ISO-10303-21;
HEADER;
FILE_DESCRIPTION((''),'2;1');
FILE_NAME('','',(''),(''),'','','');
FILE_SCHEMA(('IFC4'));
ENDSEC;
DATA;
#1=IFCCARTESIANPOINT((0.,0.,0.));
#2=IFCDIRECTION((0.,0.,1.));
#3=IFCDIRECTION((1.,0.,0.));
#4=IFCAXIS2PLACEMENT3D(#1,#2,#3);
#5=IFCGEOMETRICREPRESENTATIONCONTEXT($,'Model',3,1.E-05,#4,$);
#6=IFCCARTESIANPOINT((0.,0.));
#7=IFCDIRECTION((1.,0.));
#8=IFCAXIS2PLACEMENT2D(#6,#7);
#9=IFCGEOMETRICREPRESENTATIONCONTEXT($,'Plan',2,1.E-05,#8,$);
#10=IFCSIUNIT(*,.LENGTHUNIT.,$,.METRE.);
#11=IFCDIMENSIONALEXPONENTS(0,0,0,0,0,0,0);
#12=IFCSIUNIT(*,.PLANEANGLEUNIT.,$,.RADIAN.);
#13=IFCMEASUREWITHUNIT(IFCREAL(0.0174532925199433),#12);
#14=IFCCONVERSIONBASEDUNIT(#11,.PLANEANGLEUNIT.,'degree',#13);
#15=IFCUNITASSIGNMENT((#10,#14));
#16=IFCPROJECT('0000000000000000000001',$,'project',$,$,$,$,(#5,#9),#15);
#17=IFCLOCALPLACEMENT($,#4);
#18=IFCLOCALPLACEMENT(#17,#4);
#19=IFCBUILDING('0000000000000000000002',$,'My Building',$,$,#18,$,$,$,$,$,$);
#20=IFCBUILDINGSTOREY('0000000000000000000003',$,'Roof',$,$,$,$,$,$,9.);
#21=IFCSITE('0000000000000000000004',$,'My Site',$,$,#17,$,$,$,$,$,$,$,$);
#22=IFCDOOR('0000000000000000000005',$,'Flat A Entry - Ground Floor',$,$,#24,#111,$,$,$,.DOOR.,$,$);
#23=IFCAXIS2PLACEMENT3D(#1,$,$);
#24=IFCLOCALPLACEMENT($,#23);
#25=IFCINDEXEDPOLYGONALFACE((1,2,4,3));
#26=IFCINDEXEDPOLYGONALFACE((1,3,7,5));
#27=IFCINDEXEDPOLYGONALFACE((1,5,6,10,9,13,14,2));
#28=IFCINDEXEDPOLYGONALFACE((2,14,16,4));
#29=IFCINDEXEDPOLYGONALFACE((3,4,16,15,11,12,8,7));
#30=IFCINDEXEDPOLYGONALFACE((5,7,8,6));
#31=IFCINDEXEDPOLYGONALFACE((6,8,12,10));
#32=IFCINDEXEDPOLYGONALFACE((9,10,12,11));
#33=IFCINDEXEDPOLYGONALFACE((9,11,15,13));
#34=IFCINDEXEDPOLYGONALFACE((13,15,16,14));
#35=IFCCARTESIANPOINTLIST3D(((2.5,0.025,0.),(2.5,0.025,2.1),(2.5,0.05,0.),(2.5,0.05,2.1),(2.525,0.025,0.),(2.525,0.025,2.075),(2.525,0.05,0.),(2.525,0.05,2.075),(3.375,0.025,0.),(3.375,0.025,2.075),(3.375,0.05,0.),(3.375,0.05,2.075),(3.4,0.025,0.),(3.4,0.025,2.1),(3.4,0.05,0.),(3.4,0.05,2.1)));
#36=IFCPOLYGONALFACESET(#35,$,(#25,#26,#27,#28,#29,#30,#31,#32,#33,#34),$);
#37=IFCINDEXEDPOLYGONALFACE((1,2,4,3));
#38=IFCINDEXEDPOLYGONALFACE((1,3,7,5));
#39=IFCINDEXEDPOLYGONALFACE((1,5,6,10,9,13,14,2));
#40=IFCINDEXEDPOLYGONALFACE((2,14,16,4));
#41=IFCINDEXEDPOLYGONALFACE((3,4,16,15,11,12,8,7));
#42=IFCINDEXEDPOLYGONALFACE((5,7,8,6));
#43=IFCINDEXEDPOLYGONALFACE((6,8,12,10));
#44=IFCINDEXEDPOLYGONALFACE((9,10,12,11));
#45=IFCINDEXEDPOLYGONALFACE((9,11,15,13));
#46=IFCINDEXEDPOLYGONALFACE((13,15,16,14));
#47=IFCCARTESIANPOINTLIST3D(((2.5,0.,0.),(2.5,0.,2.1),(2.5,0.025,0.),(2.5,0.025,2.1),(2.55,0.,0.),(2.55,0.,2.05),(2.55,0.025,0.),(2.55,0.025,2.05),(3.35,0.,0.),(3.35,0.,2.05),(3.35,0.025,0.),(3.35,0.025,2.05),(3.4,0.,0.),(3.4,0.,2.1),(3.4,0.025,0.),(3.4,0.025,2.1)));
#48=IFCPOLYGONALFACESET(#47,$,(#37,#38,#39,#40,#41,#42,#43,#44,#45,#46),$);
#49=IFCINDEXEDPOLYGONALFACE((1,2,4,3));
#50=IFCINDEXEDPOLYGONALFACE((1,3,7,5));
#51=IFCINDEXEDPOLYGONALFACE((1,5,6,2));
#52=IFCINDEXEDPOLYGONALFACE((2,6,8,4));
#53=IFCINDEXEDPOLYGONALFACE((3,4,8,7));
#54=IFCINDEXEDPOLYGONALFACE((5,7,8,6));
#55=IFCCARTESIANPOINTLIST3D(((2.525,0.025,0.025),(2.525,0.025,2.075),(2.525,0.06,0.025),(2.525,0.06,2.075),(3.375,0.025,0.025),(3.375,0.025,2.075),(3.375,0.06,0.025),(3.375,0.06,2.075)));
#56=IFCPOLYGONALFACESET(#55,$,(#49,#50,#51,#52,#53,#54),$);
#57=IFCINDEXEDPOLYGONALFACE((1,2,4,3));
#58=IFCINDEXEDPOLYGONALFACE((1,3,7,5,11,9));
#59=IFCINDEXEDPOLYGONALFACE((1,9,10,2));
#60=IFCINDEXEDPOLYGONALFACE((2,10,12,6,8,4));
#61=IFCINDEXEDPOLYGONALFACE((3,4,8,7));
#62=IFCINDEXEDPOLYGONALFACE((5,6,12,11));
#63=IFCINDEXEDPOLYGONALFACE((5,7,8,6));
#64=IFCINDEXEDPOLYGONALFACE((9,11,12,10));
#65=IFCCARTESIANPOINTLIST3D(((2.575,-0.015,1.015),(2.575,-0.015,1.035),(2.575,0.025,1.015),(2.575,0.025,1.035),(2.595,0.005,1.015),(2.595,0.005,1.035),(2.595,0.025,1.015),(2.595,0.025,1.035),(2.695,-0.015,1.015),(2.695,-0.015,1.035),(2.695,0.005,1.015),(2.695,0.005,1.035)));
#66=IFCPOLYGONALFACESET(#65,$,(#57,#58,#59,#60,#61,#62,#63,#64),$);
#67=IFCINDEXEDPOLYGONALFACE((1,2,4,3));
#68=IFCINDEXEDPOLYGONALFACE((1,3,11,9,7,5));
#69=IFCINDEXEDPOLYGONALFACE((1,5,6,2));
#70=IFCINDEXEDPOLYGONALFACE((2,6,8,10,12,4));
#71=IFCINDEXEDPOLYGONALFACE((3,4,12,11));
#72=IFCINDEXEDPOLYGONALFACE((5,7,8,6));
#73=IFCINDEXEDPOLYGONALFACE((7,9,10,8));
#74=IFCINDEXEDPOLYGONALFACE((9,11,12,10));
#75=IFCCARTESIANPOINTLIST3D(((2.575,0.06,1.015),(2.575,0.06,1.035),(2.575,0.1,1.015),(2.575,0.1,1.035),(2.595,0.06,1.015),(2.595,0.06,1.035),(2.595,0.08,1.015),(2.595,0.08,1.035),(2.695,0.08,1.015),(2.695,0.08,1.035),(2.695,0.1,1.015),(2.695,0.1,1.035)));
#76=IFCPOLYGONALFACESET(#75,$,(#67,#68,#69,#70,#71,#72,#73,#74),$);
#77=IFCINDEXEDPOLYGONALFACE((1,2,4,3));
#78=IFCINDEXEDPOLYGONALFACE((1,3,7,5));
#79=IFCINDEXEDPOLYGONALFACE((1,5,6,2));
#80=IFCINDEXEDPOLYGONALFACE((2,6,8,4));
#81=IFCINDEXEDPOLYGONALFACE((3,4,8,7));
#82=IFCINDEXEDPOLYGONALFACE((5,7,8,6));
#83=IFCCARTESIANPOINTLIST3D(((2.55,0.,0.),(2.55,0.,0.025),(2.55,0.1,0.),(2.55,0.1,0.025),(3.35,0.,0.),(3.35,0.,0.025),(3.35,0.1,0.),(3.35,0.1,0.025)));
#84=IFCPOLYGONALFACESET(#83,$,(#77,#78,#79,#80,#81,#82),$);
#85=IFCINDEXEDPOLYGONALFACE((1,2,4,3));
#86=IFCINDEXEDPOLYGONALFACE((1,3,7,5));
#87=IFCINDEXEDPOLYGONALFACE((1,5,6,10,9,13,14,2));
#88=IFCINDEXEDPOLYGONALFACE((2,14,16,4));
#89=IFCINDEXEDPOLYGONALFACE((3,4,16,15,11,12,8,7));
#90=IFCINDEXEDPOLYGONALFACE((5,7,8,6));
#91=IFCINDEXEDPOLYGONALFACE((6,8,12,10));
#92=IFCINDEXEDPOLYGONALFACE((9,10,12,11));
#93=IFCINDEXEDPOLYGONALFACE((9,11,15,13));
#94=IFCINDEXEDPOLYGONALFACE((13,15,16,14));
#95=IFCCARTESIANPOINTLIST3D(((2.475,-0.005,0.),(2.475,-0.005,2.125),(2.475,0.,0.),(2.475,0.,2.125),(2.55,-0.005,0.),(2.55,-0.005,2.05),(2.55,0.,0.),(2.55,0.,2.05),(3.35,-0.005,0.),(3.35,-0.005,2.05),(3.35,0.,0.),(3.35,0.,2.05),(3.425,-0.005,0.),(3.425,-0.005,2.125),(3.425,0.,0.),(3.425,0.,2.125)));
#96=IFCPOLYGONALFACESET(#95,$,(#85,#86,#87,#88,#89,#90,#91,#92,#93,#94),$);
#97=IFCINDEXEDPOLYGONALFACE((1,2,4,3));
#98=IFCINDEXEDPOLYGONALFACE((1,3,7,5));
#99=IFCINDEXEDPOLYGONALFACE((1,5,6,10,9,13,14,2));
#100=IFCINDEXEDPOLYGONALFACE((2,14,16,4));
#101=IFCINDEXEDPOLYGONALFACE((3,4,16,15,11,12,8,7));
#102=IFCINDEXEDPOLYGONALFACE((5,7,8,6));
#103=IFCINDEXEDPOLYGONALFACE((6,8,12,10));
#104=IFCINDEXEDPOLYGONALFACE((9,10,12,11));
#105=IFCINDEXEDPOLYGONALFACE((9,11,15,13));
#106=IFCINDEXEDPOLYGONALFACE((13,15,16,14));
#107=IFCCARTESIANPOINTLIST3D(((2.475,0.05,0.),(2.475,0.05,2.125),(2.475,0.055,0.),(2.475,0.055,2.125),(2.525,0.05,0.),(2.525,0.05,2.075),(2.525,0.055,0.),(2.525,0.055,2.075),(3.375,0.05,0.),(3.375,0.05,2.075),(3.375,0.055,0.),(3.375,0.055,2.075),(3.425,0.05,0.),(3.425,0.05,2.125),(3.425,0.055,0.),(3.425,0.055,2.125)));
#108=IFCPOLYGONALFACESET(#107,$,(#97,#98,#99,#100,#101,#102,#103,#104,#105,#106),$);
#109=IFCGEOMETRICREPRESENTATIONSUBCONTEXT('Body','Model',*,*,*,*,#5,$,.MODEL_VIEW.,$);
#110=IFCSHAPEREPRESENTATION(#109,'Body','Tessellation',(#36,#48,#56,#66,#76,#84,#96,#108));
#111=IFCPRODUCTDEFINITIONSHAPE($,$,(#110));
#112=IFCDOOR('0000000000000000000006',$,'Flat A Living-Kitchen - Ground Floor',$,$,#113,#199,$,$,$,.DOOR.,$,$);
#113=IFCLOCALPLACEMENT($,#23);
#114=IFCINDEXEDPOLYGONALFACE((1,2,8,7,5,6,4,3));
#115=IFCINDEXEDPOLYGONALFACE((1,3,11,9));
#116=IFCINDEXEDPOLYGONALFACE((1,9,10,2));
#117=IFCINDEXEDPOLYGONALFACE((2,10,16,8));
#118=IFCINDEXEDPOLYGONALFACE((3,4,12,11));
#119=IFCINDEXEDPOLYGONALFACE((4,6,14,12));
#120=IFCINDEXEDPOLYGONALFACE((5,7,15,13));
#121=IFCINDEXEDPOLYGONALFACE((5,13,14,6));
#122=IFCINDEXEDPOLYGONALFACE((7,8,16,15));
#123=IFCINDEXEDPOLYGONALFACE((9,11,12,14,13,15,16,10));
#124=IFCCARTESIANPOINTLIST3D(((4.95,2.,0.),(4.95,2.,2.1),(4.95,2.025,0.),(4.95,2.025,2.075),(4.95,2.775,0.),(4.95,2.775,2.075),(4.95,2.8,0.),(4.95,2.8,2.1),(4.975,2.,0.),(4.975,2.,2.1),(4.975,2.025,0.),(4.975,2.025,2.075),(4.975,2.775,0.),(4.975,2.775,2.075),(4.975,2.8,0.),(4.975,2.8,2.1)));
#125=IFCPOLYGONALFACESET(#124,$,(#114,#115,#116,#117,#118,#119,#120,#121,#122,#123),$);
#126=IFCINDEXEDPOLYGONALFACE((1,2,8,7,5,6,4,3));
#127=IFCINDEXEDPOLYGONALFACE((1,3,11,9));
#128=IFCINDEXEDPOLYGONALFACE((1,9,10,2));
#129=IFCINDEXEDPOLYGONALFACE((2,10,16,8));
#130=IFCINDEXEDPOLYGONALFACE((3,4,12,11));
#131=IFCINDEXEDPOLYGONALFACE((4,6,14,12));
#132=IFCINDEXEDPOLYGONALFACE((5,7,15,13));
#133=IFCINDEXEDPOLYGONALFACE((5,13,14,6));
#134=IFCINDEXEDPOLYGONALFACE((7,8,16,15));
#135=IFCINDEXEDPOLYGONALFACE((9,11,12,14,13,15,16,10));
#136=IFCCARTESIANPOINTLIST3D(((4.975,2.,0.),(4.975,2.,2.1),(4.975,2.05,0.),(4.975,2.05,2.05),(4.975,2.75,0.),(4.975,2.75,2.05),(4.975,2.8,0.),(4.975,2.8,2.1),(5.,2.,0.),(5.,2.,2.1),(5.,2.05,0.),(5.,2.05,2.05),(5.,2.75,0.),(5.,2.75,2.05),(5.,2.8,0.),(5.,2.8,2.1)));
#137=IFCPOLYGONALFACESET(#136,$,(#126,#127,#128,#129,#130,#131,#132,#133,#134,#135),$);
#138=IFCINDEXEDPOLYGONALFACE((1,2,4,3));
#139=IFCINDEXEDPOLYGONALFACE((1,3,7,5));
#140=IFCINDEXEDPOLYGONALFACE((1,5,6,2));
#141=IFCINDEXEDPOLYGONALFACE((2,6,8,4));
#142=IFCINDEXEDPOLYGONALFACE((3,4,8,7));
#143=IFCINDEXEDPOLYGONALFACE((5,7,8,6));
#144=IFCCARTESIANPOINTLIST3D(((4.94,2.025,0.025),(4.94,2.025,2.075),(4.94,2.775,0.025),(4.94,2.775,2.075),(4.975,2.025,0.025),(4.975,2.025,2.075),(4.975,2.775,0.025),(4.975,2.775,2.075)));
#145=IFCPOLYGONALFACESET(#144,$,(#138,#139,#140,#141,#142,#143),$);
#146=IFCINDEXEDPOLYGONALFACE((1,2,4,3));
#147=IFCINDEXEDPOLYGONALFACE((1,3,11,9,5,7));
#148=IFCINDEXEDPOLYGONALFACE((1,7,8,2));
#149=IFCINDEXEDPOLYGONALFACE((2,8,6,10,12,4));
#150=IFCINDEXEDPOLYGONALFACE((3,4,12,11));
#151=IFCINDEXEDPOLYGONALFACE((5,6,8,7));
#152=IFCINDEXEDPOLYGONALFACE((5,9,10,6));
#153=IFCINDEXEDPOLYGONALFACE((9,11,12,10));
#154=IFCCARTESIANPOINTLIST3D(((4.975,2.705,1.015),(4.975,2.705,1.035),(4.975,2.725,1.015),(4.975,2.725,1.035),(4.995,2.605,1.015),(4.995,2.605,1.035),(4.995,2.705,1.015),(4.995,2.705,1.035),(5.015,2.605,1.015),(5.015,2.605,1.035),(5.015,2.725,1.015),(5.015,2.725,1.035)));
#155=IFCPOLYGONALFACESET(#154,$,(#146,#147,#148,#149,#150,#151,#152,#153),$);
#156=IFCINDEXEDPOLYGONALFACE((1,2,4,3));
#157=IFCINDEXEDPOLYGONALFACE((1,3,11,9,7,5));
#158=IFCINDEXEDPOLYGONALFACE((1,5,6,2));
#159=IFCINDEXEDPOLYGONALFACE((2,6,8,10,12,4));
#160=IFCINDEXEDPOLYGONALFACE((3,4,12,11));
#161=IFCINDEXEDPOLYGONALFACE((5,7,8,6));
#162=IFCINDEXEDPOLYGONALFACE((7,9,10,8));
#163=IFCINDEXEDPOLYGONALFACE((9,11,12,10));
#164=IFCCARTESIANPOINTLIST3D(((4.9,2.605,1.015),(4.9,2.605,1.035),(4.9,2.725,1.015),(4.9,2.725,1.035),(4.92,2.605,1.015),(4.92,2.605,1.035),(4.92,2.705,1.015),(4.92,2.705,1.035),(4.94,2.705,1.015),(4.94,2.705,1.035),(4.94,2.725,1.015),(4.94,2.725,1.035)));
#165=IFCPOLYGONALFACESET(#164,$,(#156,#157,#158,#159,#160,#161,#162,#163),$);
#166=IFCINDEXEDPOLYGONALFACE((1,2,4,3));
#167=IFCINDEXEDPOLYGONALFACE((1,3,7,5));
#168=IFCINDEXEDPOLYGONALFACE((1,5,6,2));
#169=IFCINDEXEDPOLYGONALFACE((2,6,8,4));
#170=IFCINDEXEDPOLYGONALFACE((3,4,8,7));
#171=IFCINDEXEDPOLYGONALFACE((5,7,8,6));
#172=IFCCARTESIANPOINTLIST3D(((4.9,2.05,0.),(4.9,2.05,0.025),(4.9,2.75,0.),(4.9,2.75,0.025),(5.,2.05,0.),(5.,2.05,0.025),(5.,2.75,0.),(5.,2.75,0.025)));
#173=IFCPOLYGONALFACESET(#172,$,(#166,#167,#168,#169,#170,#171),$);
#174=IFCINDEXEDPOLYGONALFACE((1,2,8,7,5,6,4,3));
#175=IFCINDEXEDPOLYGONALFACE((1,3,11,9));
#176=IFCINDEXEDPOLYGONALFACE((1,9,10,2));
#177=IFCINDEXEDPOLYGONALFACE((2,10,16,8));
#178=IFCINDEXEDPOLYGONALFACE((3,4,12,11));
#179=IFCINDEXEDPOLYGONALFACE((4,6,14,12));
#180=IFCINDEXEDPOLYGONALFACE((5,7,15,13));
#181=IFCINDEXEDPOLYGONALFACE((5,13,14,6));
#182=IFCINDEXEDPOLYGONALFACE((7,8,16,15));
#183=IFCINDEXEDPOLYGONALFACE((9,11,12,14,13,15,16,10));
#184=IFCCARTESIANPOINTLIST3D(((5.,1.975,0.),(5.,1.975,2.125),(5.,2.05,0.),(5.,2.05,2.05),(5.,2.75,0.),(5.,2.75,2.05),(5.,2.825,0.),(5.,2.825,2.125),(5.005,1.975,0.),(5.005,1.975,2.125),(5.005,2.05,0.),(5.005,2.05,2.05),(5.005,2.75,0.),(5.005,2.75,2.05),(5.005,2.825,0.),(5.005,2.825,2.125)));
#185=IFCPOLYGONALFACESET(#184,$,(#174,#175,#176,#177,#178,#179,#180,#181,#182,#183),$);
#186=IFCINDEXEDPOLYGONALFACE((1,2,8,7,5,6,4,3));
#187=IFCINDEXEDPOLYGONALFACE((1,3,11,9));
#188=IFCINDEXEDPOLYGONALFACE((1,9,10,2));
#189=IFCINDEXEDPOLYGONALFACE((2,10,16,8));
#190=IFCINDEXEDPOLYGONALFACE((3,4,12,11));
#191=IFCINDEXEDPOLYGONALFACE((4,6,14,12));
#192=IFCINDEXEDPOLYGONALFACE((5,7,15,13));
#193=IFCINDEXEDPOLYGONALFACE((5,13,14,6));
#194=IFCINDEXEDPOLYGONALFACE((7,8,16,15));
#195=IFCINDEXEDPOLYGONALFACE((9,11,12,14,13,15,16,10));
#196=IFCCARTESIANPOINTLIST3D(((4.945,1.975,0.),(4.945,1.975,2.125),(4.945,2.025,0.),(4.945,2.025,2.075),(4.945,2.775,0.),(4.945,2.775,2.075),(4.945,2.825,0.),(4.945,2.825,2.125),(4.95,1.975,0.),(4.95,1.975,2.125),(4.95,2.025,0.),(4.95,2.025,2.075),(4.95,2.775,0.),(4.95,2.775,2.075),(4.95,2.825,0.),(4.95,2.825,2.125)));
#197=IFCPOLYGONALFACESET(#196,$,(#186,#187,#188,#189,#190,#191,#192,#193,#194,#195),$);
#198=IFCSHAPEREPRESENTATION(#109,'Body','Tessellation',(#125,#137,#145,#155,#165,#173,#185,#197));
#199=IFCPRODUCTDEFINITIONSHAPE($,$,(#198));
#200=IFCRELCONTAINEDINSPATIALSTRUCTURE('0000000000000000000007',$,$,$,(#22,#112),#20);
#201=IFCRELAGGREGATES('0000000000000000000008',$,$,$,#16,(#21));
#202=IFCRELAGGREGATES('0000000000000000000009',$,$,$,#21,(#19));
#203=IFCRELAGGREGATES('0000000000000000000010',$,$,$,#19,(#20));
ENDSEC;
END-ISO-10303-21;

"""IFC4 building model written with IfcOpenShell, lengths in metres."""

from ifc_helpers import new_model, entity, si_unit, converted_unit, frame, origin_with_axes, origin_2d_with_axis, place, context, subcontext, project, spatial, line, indexed_curve, outline, extrude, element, save


model = new_model("IFC4")

# Units and contexts
model_context = context("Model", 3, precision=1e-05, world=origin_with_axes())
plan_context = context("Plan", 2, precision=1e-05, world=origin_2d_with_axis())
body_context = subcontext(model_context, "Body", "Model", "MODEL_VIEW")
ifc_project = project(units=[si_unit("LENGTHUNIT", "METRE"), converted_unit("PLANEANGLEUNIT", "degree", entity("IfcReal", 0.0174532925199433), si_unit("PLANEANGLEUNIT", "RADIAN"), dimensions=[0, 0, 0, 0, 0, 0, 0])], contexts=[model_context, plan_context])

# Site, building, storey
site_placement = place(None, origin_with_axes())
site = spatial("IfcSite", under=ifc_project, at=site_placement, Name="My Site")
building_placement = place(site_placement, origin_with_axes())
building = spatial("IfcBuilding", under=site, at=building_placement, Name="My Building")
storey = spatial("IfcBuildingStorey", under=building, Name="Roof", Elevation=9.0)

# Doors
door_1_placement = place(None, frame((2.5, 0.0, 0.0), z_axis=(0.0, 0.0, 1.0), x_axis=(1.0, 0.0, 0.0)))
element("IfcDoor", 1, at=door_1_placement, inside=storey, Name="Flat A Entry - Ground Floor", PredefinedType="DOOR", context=body_context, shape_type="SweptSolid", body=[
    extrude(outline(indexed_curve([(0.0, 0.0), (0.0, 2.1), (0.9, 2.1), (0.9, 0.0), (0.875, 0.0), (0.875, 2.075), (0.025, 2.075), (0.025, 0.0)], segments=[line(1, 2, 3, 4, 5, 6, 7, 8, 1)])), frame((0.0, 0.025, 0.0), z_axis=(0.0, -1.0, 0.0), x_axis=(1.0, 0.0, 0.0)), (0.0, 0.0, -1.0), 0.025),
    extrude(outline(indexed_curve([(0.0, 0.0), (0.0, 2.1), (0.9, 2.1), (0.9, 0.0), (0.85, 0.0), (0.85, 2.05), (0.05, 2.05), (0.05, 0.0)], segments=[line(1, 2, 3, 4, 5, 6, 7, 8, 1)])), frame((0.0, 0.0, 0.0), z_axis=(0.0, -1.0, 0.0), x_axis=(1.0, 0.0, 0.0)), (0.0, 0.0, -1.0), 0.025),
    extrude(outline(indexed_curve([(0.0, 0.0), (0.85, 0.0), (0.85, 0.035), (0.0, 0.035)], segments=[line(1, 2, 3, 4, 1)])), frame((0.025, 0.025, 0.025), z_axis=(0.0, 0.0, 1.0), x_axis=(1.0, 0.0, 0.0)), (0.0, 0.0, 1.0), 2.05),
    extrude(outline(indexed_curve([(0.0, 0.0), (0.0, -0.04), (0.12, -0.04), (0.12, -0.02), (0.02, -0.02), (0.02, 0.0)], segments=[line(1, 2, 3, 4, 5, 6, 1)])), frame((0.075, 0.025, 1.015), z_axis=(0.0, 0.0, 1.0), x_axis=(1.0, 0.0, 0.0)), (0.0, 0.0, 1.0), 0.02),
    extrude(outline(indexed_curve([(0.0, 0.0), (0.0, 0.04), (0.12, 0.04), (0.12, 0.02), (0.02, 0.02), (0.02, 0.0)], segments=[line(1, 2, 3, 4, 5, 6, 1)])), frame((0.075, 0.06, 1.015), z_axis=(0.0, 0.0, 1.0), x_axis=(1.0, 0.0, 0.0)), (0.0, 0.0, 1.0), 0.02),
    extrude(outline(indexed_curve([(0.0, 0.0), (0.8, 0.0), (0.8, 0.1), (0.0, 0.1)], segments=[line(1, 2, 3, 4, 1)])), frame((0.05, 0.0, 0.0), z_axis=(0.0, 0.0, 1.0), x_axis=(1.0, 0.0, 0.0)), (0.0, 0.0, 1.0), 0.025),
    extrude(outline(indexed_curve([(0.0, 0.0), (0.0, 2.125), (0.95, 2.125), (0.95, 0.0), (0.875, 0.0), (0.875, 2.05), (0.075, 2.05), (0.075, 0.0)], segments=[line(1, 2, 3, 4, 5, 6, 7, 8, 1)])), frame((-0.025, -0.005, 0.0), z_axis=(0.0, -1.0, 0.0), x_axis=(1.0, 0.0, 0.0)), (0.0, 0.0, -1.0), 0.005),
    extrude(outline(indexed_curve([(0.0, 0.0), (0.0, 2.125), (0.95, 2.125), (0.95, 0.0), (0.9, 0.0), (0.9, 2.075), (0.05, 2.075), (0.05, 0.0)], segments=[line(1, 2, 3, 4, 5, 6, 7, 8, 1)])), frame((-0.025, 0.05, 0.0), z_axis=(0.0, -1.0, 0.0), x_axis=(1.0, 0.0, 0.0)), (0.0, 0.0, -1.0), 0.005),
])
door_2_placement = place(None, frame((5.0, 2.0, 0.0), z_axis=(0.0, 0.0, 1.0), x_axis=(0.0, 1.0, 0.0)))
element("IfcDoor", 2, at=door_2_placement, inside=storey, Name="Flat A Living-Kitchen - Ground Floor", PredefinedType="DOOR", context=body_context, shape_type="SweptSolid", body=[
    extrude(outline(indexed_curve([(0.0, 0.0), (0.0, 2.1), (0.8, 2.1), (0.8, 0.0), (0.775, 0.0), (0.775, 2.075), (0.025, 2.075), (0.025, 0.0)], segments=[line(1, 2, 3, 4, 5, 6, 7, 8, 1)])), frame((0.0, 0.025, 0.0), z_axis=(0.0, -1.0, 0.0), x_axis=(1.0, 0.0, 0.0)), (0.0, 0.0, -1.0), 0.025),
    extrude(outline(indexed_curve([(0.0, 0.0), (0.0, 2.1), (0.8, 2.1), (0.8, 0.0), (0.75, 0.0), (0.75, 2.05), (0.05, 2.05), (0.05, 0.0)], segments=[line(1, 2, 3, 4, 5, 6, 7, 8, 1)])), frame((0.0, 0.0, 0.0), z_axis=(0.0, -1.0, 0.0), x_axis=(1.0, 0.0, 0.0)), (0.0, 0.0, -1.0), 0.025),
    extrude(outline(indexed_curve([(0.0, 0.0), (0.75, 0.0), (0.75, 0.035), (0.0, 0.035)], segments=[line(1, 2, 3, 4, 1)])), frame((0.025, 0.025, 0.025), z_axis=(0.0, 0.0, 1.0), x_axis=(1.0, 0.0, 0.0)), (0.0, 0.0, 1.0), 2.05),
    extrude(outline(indexed_curve([(0.0, 0.0), (0.0, -0.04), (-0.12, -0.04), (-0.12, -0.02), (-0.02, -0.02), (-0.02, 0.0)], segments=[line(1, 2, 3, 4, 5, 6, 1)])), frame((0.725, 0.025, 1.015), z_axis=(0.0, 0.0, 1.0), x_axis=(1.0, 0.0, 0.0)), (0.0, 0.0, 1.0), 0.02),
    extrude(outline(indexed_curve([(0.0, 0.0), (0.0, 0.04), (-0.12, 0.04), (-0.12, 0.02), (-0.02, 0.02), (-0.02, 0.0)], segments=[line(1, 2, 3, 4, 5, 6, 1)])), frame((0.725, 0.06, 1.015), z_axis=(0.0, 0.0, 1.0), x_axis=(1.0, 0.0, 0.0)), (0.0, 0.0, 1.0), 0.02),
    extrude(outline(indexed_curve([(0.0, 0.0), (0.7, 0.0), (0.7, 0.1), (0.0, 0.1)], segments=[line(1, 2, 3, 4, 1)])), frame((0.05, 0.0, 0.0), z_axis=(0.0, 0.0, 1.0), x_axis=(1.0, 0.0, 0.0)), (0.0, 0.0, 1.0), 0.025),
    extrude(outline(indexed_curve([(0.0, 0.0), (0.0, 2.125), (0.85, 2.125), (0.85, 0.0), (0.775, 0.0), (0.775, 2.05), (0.075, 2.05), (0.075, 0.0)], segments=[line(1, 2, 3, 4, 5, 6, 7, 8, 1)])), frame((-0.025, -0.005, 0.0), z_axis=(0.0, -1.0, 0.0), x_axis=(1.0, 0.0, 0.0)), (0.0, 0.0, -1.0), 0.005),
    extrude(outline(indexed_curve([(0.0, 0.0), (0.0, 2.125), (0.85, 2.125), (0.85, 0.0), (0.8, 0.0), (0.8, 2.075), (0.05, 2.075), (0.05, 0.0)], segments=[line(1, 2, 3, 4, 5, 6, 7, 8, 1)])), frame((-0.025, 0.05, 0.0), z_axis=(0.0, -1.0, 0.0), x_axis=(1.0, 0.0, 0.0)), (0.0, 0.0, -1.0), 0.005),
])

save(model, "model.ifc")
